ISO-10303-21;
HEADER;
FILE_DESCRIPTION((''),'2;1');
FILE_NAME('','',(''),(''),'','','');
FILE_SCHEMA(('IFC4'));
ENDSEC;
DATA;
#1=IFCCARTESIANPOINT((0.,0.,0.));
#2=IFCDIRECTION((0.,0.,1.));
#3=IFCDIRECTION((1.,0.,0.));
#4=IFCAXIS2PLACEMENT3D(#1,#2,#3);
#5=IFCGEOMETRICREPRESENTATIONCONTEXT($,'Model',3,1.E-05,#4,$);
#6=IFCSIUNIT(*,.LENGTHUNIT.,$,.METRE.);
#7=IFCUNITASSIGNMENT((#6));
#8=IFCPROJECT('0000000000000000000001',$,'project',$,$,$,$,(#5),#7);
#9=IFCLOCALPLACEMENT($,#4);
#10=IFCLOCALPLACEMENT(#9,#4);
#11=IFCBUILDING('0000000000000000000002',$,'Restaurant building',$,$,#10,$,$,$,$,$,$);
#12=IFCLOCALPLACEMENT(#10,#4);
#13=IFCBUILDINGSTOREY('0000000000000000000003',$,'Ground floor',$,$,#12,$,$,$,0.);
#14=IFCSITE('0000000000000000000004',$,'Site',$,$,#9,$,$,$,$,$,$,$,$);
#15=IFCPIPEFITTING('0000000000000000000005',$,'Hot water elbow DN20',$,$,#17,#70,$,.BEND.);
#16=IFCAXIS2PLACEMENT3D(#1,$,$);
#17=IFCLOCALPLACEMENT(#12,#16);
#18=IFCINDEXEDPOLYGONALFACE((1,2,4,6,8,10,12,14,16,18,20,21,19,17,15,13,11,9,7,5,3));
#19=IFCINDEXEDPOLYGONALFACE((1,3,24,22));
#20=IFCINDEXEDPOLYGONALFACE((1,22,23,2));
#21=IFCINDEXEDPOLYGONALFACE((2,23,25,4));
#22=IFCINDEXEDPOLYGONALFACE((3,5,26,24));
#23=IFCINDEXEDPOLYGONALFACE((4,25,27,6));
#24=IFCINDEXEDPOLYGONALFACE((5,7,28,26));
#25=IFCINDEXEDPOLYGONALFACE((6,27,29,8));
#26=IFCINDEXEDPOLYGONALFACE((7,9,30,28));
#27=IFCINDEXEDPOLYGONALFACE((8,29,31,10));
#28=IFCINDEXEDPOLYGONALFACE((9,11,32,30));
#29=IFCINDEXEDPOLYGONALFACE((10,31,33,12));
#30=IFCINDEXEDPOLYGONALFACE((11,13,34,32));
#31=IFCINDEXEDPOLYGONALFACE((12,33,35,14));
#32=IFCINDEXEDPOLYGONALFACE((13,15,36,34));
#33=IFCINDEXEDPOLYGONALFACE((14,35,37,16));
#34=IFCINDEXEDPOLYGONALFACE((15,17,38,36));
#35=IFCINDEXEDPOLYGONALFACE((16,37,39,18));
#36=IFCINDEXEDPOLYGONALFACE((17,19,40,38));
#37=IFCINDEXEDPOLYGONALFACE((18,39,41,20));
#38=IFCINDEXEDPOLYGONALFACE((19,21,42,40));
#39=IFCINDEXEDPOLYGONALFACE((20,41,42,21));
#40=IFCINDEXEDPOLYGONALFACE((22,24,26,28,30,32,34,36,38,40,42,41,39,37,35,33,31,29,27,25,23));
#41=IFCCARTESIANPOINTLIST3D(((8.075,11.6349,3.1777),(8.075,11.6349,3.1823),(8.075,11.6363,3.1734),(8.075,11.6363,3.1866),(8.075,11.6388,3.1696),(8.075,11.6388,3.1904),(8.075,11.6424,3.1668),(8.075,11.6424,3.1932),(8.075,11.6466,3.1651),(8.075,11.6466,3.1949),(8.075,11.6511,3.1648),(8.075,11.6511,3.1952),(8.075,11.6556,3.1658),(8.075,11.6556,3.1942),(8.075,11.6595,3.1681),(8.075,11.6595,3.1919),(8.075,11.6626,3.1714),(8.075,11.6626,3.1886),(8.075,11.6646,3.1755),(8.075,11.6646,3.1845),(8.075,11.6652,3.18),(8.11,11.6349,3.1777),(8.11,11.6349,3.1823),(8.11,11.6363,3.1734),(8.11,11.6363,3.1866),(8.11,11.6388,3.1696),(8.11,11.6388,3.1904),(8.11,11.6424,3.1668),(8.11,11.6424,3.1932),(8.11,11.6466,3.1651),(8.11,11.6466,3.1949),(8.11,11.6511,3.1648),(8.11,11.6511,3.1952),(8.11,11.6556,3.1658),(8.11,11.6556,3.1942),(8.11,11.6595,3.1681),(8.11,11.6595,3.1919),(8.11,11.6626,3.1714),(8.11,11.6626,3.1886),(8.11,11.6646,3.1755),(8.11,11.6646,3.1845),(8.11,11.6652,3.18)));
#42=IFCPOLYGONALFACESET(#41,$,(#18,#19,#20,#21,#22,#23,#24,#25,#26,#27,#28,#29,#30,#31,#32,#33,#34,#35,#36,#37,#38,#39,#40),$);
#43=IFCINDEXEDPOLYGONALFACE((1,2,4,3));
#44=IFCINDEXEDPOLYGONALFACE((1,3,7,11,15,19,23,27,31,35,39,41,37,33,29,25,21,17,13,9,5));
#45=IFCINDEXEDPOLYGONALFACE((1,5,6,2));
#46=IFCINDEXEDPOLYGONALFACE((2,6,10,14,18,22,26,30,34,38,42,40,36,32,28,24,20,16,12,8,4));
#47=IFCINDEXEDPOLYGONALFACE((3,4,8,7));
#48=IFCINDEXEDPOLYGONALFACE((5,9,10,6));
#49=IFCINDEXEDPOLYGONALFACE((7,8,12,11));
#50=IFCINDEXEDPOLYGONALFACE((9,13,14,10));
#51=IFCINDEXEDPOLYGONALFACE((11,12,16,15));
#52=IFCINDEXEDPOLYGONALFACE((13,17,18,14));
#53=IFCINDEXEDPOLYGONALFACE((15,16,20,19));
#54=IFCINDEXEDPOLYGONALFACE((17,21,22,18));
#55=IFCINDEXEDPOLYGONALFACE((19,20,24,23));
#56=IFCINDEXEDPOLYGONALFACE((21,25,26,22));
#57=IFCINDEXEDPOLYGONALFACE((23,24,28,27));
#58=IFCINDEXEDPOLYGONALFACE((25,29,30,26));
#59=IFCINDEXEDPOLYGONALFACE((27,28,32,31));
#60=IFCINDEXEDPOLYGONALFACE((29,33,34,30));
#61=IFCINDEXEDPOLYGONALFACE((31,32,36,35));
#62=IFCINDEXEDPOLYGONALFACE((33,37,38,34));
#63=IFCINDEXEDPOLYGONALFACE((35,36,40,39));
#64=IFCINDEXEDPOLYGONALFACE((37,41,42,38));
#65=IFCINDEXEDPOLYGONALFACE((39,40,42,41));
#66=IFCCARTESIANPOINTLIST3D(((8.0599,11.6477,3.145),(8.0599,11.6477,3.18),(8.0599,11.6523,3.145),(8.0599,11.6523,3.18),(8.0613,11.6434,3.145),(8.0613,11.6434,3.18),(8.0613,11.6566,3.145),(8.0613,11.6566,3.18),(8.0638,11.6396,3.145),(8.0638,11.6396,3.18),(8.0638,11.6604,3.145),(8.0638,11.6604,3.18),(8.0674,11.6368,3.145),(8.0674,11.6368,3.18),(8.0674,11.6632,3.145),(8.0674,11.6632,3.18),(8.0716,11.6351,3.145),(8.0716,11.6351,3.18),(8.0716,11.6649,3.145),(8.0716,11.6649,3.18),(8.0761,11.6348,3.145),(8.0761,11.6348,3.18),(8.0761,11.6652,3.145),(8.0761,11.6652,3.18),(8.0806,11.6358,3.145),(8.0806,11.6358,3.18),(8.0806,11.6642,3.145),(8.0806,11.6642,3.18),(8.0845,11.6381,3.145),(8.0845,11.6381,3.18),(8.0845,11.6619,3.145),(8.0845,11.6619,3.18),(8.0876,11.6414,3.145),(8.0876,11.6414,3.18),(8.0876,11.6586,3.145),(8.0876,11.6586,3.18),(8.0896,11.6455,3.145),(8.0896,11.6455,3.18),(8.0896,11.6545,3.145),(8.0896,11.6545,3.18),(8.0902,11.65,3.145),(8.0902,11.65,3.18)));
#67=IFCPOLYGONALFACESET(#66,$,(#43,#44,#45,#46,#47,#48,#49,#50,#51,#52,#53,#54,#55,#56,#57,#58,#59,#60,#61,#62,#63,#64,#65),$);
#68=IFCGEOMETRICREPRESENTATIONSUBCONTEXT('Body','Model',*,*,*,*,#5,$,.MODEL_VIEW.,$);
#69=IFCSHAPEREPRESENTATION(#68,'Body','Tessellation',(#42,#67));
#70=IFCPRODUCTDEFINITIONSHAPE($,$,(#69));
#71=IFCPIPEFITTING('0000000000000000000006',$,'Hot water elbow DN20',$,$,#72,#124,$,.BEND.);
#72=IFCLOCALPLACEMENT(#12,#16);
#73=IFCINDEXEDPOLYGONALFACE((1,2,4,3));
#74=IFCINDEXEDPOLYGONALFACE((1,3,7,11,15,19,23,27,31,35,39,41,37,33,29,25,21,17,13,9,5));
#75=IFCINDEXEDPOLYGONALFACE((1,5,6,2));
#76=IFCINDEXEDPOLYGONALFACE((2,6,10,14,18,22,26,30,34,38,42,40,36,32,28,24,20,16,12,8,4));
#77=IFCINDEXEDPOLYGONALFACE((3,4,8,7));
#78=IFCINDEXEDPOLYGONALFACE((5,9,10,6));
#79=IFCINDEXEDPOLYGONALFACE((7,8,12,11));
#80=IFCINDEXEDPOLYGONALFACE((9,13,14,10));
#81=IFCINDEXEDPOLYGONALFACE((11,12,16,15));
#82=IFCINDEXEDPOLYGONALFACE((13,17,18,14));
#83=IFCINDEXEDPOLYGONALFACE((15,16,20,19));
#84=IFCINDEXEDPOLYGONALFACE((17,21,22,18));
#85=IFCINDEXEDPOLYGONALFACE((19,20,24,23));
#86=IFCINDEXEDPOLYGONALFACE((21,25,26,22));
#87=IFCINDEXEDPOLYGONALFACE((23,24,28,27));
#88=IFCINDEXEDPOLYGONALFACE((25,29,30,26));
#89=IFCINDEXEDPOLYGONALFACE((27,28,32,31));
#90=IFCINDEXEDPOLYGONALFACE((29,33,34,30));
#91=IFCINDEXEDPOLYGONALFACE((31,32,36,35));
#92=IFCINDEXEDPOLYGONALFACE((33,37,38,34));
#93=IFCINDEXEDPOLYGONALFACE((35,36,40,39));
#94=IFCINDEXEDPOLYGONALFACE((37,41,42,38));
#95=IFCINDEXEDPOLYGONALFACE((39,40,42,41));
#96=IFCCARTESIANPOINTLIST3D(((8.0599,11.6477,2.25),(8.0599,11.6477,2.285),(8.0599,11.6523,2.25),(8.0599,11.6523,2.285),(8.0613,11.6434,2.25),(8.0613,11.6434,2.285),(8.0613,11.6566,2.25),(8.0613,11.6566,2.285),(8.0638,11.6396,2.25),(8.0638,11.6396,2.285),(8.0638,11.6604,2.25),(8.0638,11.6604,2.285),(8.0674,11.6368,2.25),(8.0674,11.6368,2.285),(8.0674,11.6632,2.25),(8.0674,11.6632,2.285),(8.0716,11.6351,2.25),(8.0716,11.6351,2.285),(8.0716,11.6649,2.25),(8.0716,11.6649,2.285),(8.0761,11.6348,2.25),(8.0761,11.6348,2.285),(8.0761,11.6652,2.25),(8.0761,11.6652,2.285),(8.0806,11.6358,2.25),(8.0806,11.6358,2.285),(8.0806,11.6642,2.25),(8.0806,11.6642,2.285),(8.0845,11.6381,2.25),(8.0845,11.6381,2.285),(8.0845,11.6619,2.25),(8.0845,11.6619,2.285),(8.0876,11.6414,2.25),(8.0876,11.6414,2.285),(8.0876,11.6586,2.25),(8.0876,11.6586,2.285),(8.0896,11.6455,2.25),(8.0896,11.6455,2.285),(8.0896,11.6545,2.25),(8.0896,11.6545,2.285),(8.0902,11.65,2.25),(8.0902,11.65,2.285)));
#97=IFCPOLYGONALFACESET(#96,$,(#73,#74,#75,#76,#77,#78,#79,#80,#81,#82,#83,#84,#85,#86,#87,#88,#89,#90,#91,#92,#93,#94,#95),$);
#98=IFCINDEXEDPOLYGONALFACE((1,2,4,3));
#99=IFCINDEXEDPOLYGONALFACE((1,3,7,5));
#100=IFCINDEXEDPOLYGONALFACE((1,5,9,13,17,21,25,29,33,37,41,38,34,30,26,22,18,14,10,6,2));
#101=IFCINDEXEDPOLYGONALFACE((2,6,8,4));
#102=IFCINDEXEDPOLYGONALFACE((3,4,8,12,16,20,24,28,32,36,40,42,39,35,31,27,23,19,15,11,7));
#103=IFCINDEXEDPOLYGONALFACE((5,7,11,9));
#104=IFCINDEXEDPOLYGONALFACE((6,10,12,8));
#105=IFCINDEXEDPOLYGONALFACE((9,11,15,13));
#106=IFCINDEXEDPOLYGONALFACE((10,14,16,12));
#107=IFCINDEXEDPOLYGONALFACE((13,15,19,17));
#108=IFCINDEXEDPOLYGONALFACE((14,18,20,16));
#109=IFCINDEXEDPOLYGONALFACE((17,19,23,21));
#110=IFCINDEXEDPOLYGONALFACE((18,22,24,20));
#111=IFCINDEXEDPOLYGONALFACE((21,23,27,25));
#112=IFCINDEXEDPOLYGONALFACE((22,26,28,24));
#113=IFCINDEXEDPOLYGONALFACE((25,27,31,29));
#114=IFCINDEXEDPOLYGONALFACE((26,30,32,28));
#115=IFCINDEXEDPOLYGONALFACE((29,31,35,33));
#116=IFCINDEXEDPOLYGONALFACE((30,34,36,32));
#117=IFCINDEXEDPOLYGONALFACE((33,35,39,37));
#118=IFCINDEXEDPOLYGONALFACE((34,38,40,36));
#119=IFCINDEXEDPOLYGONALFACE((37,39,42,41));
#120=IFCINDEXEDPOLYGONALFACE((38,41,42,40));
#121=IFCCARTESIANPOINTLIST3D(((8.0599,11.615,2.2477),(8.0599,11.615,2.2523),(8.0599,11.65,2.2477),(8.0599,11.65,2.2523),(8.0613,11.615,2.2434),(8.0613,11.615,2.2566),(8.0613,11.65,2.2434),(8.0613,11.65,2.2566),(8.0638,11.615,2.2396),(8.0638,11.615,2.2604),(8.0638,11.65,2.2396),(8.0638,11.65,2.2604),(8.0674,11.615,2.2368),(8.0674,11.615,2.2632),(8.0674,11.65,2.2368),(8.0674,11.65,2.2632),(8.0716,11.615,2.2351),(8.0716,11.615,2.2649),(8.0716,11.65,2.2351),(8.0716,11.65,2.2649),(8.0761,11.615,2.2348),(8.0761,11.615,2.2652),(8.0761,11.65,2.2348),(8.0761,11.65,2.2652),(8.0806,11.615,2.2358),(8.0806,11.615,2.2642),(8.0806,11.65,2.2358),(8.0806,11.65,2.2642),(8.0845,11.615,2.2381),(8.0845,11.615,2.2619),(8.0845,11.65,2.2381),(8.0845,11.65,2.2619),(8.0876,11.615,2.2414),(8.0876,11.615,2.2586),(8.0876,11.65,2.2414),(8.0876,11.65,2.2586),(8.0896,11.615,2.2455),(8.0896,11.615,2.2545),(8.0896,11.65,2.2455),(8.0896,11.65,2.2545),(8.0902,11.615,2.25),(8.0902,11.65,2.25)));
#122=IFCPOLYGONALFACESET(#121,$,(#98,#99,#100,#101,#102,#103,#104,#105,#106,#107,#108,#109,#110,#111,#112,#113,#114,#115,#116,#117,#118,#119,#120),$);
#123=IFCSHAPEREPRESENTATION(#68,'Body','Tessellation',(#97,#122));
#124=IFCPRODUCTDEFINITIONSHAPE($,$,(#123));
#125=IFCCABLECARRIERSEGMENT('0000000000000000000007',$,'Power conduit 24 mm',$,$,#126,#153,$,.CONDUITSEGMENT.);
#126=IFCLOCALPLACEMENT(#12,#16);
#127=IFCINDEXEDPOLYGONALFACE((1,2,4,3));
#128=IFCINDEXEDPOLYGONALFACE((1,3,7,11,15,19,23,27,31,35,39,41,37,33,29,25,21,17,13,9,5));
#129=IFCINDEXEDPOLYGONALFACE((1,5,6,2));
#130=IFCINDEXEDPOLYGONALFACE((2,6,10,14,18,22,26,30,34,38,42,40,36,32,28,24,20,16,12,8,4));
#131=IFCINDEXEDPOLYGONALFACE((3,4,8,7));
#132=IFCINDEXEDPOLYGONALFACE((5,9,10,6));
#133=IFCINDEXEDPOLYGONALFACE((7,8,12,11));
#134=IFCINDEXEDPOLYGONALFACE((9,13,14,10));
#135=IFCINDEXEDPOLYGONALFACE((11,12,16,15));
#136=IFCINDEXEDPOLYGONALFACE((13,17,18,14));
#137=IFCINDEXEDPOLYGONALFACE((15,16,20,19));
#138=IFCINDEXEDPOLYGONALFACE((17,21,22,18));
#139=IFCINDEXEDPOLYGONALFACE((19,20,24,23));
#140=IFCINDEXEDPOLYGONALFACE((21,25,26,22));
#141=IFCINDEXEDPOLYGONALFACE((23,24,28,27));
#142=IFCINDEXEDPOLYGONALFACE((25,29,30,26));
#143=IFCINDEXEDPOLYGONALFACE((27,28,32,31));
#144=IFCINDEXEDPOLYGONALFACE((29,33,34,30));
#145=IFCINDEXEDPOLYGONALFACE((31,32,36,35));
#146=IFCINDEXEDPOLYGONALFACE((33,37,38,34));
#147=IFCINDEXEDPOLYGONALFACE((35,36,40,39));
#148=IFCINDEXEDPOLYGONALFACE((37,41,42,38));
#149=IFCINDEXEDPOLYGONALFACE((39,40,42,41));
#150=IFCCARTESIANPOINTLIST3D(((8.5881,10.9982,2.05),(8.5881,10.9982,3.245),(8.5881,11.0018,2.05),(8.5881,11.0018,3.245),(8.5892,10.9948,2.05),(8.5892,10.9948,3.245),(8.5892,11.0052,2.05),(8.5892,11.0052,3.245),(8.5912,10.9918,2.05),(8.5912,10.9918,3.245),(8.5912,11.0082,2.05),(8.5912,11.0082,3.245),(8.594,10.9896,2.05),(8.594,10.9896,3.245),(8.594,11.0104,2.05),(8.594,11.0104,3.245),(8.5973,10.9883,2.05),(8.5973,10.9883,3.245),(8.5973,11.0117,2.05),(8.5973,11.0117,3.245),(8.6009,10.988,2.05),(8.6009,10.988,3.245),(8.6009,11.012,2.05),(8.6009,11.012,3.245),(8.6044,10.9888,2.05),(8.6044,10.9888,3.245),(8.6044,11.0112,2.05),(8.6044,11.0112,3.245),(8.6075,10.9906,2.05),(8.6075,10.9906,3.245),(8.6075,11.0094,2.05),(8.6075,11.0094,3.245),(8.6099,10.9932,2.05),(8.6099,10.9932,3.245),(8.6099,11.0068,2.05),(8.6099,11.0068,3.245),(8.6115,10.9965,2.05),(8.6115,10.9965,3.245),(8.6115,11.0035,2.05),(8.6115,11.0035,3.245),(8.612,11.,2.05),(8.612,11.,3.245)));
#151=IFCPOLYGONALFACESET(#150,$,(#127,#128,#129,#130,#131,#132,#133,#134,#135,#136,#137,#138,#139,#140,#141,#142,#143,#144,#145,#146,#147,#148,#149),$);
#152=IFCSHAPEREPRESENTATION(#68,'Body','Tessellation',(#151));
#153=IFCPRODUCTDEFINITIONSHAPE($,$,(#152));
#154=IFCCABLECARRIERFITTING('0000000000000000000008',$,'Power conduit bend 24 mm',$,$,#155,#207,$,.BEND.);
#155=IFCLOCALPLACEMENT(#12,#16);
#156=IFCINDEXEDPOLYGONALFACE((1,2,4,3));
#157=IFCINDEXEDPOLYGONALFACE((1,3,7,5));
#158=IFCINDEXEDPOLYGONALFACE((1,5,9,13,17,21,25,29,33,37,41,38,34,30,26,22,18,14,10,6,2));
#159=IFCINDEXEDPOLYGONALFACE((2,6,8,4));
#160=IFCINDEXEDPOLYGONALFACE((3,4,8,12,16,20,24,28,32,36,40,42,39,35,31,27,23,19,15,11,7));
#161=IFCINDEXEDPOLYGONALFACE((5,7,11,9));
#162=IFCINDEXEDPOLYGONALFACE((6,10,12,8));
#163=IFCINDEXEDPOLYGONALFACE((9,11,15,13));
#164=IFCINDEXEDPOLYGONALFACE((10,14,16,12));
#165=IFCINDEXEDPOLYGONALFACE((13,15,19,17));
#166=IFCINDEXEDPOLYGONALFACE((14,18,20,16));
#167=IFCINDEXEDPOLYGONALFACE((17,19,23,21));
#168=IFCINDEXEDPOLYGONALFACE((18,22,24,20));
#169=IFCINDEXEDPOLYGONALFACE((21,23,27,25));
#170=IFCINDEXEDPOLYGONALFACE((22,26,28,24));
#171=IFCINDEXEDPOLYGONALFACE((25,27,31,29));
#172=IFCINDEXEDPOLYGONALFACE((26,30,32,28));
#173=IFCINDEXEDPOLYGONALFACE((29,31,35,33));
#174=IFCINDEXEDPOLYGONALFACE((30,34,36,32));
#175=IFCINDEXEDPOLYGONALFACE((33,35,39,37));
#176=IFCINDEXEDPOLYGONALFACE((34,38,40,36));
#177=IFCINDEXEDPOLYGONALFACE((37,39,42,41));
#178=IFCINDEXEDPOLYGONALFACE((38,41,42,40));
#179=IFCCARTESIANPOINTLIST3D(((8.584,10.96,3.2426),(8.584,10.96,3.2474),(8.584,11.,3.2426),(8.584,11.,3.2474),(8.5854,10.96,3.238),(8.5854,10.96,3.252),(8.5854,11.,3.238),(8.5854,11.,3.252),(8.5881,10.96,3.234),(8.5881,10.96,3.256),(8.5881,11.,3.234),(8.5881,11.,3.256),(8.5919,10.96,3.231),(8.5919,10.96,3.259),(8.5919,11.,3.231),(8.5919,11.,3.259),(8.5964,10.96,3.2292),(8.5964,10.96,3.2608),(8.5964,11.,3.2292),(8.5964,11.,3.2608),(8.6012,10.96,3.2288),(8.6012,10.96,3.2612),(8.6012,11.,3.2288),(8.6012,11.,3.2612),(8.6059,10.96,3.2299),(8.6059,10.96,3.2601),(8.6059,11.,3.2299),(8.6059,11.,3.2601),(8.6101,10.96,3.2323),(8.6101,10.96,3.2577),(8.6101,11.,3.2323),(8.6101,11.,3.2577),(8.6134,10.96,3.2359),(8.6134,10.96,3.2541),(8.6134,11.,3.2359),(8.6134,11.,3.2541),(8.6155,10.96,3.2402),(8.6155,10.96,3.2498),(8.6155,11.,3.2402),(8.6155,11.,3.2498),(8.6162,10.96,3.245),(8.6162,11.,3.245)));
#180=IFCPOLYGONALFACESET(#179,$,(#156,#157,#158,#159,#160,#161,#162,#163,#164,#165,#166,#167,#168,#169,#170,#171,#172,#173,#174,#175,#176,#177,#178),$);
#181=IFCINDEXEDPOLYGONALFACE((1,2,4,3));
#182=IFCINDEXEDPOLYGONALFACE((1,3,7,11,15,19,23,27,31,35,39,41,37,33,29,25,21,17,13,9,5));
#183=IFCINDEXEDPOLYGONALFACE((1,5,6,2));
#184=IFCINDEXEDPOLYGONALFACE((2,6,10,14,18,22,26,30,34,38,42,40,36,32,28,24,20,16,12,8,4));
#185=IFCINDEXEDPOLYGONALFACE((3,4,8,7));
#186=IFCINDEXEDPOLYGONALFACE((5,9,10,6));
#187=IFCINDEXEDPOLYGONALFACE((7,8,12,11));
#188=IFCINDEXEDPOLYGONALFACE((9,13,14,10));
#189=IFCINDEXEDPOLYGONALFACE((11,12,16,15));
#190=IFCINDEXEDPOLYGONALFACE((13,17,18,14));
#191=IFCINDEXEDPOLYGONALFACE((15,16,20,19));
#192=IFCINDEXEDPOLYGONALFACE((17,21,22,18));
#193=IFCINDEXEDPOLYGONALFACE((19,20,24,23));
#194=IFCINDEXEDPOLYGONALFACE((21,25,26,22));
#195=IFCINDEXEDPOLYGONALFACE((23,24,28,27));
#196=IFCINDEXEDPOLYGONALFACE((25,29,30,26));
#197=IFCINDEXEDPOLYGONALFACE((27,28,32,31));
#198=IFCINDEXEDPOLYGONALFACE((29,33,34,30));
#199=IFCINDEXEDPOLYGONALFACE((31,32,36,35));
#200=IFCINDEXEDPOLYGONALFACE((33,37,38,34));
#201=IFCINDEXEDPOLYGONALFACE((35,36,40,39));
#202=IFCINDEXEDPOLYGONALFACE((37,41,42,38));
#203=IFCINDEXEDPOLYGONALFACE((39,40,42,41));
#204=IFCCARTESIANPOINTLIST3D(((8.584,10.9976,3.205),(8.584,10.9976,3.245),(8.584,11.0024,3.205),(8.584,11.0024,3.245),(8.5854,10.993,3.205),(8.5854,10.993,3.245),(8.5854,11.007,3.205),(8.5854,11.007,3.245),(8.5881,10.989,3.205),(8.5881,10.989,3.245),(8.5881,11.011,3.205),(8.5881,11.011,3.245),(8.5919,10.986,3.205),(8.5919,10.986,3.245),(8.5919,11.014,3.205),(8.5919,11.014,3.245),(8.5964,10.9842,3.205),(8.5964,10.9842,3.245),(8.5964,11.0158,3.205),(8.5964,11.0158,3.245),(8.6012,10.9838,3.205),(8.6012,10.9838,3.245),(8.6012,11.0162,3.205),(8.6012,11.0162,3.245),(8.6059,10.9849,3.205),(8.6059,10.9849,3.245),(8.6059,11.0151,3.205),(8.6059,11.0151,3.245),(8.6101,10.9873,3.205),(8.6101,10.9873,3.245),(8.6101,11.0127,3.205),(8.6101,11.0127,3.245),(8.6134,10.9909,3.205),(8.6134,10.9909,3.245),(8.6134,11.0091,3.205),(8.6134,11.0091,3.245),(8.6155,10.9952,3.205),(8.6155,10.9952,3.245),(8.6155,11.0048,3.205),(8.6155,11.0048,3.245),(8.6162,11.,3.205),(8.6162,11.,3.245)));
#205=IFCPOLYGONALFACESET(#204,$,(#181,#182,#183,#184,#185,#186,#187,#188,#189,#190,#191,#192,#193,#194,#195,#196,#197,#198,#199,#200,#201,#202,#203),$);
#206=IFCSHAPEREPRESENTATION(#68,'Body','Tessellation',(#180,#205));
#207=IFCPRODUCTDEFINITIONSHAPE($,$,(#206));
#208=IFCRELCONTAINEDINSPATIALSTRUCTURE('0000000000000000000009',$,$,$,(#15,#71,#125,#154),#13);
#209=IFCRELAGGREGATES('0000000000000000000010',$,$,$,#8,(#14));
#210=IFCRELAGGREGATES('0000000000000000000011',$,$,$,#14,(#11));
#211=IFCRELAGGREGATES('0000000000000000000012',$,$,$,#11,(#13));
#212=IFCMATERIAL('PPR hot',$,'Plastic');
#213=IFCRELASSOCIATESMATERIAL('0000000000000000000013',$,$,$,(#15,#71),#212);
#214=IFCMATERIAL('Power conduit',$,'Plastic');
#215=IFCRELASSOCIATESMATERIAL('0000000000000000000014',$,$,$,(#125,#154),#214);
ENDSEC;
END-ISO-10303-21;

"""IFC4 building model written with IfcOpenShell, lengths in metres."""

from ifc_helpers import new_model, si_unit, frame, origin, origin_with_axes, origin_2d, place, context, subcontext, project, spatial, circle, extrude, material, element, save


model = new_model("IFC4")

# Units and contexts
model_context = context("Model", 3, precision=1e-05, world=origin_with_axes())
body_context = subcontext(model_context, "Body", "Model", "MODEL_VIEW")
ifc_project = project(units=[si_unit("LENGTHUNIT", "METRE")], contexts=[model_context])

# Site, building, storey
site_placement = place(None, origin_with_axes())
site = spatial("IfcSite", under=ifc_project, at=site_placement, Name="Site")
building_placement = place(site_placement, origin_with_axes())
building = spatial("IfcBuilding", under=site, at=building_placement, Name="Restaurant building")
storey_placement = place(building_placement, origin_with_axes())
storey = spatial("IfcBuildingStorey", under=building, at=storey_placement, Name="Ground floor", Elevation=0.0)

# Shared definitions
ifc_material_1 = material(Name="PPR hot", Category="Plastic")

# Pipe fittings
pipe_fitting_1_placement = place(storey_placement, frame((8.075, 11.65, 3.18)))
element("IfcPipeFitting", 1, at=pipe_fitting_1_placement, inside=storey, material=ifc_material_1, Name="Hot water elbow DN20", PredefinedType="BEND", context=body_context, shape_type="SweptSolid", body=[
    extrude(circle(Radius=0.0152, at=origin_2d()), frame((0.0, 0.0, 0.0), z_axis=(1.0, 0.0, 0.0), x_axis=(0.0, 1.0, 0.0)), (0.0, 0.0, 1.0), 0.035),
    extrude(circle(Radius=0.0152, at=origin_2d()), frame((0.0, 0.0, 0.0), z_axis=(0.0, 0.0, -1.0), x_axis=(1.0, 0.0, 0.0)), (0.0, 0.0, 1.0), 0.035),
])
pipe_fitting_2_placement = place(storey_placement, frame((8.075, 11.65, 2.25)))
element("IfcPipeFitting", 2, at=pipe_fitting_2_placement, inside=storey, material=ifc_material_1, Name="Hot water elbow DN20", PredefinedType="BEND", context=body_context, shape_type="SweptSolid", body=[
    extrude(circle(Radius=0.0152, at=origin_2d()), origin(), (0.0, 0.0, 1.0), 0.035),
    extrude(circle(Radius=0.0152, at=origin_2d()), frame((0.0, 0.0, 0.0), z_axis=(0.0, -1.0, 0.0), x_axis=(1.0, 0.0, 0.0)), (0.0, 0.0, 1.0), 0.035),
])

# Cable carrier segment
ifc_material_2 = material(Name="Power conduit", Category="Plastic")
cable_carrier_segment_placement = place(storey_placement, frame((8.6, 11.0, 3.245)))
element("IfcCableCarrierSegment", 3, at=cable_carrier_segment_placement, inside=storey, material=ifc_material_2, Name="Power conduit 24 mm", PredefinedType="CONDUITSEGMENT", context=body_context, shape_type="SweptSolid", body=[
    extrude(circle(Radius=0.012, at=origin_2d()), frame((0.0, 0.0, 0.0), z_axis=(0.0, 0.0, -1.0), x_axis=(1.0, 0.0, 0.0)), (0.0, 0.0, 1.0), 1.195),
])

# Cable carrier fitting
cable_carrier_fitting_placement = place(storey_placement, frame((8.6, 11.0, 3.245)))
element("IfcCableCarrierFitting", 4, at=cable_carrier_fitting_placement, inside=storey, material=ifc_material_2, Name="Power conduit bend 24 mm", PredefinedType="BEND", context=body_context, shape_type="SweptSolid", body=[
    extrude(circle(Radius=0.0162, at=origin_2d()), frame((0.0, 0.0, 0.0), z_axis=(0.0, -1.0, 0.0), x_axis=(1.0, 0.0, 0.0)), (0.0, 0.0, 1.0), 0.04),
    extrude(circle(Radius=0.0162, at=origin_2d()), frame((0.0, 0.0, 0.0), z_axis=(0.0, 0.0, -1.0), x_axis=(1.0, 0.0, 0.0)), (0.0, 0.0, 1.0), 0.04),
])

save(model, "model.ifc")
